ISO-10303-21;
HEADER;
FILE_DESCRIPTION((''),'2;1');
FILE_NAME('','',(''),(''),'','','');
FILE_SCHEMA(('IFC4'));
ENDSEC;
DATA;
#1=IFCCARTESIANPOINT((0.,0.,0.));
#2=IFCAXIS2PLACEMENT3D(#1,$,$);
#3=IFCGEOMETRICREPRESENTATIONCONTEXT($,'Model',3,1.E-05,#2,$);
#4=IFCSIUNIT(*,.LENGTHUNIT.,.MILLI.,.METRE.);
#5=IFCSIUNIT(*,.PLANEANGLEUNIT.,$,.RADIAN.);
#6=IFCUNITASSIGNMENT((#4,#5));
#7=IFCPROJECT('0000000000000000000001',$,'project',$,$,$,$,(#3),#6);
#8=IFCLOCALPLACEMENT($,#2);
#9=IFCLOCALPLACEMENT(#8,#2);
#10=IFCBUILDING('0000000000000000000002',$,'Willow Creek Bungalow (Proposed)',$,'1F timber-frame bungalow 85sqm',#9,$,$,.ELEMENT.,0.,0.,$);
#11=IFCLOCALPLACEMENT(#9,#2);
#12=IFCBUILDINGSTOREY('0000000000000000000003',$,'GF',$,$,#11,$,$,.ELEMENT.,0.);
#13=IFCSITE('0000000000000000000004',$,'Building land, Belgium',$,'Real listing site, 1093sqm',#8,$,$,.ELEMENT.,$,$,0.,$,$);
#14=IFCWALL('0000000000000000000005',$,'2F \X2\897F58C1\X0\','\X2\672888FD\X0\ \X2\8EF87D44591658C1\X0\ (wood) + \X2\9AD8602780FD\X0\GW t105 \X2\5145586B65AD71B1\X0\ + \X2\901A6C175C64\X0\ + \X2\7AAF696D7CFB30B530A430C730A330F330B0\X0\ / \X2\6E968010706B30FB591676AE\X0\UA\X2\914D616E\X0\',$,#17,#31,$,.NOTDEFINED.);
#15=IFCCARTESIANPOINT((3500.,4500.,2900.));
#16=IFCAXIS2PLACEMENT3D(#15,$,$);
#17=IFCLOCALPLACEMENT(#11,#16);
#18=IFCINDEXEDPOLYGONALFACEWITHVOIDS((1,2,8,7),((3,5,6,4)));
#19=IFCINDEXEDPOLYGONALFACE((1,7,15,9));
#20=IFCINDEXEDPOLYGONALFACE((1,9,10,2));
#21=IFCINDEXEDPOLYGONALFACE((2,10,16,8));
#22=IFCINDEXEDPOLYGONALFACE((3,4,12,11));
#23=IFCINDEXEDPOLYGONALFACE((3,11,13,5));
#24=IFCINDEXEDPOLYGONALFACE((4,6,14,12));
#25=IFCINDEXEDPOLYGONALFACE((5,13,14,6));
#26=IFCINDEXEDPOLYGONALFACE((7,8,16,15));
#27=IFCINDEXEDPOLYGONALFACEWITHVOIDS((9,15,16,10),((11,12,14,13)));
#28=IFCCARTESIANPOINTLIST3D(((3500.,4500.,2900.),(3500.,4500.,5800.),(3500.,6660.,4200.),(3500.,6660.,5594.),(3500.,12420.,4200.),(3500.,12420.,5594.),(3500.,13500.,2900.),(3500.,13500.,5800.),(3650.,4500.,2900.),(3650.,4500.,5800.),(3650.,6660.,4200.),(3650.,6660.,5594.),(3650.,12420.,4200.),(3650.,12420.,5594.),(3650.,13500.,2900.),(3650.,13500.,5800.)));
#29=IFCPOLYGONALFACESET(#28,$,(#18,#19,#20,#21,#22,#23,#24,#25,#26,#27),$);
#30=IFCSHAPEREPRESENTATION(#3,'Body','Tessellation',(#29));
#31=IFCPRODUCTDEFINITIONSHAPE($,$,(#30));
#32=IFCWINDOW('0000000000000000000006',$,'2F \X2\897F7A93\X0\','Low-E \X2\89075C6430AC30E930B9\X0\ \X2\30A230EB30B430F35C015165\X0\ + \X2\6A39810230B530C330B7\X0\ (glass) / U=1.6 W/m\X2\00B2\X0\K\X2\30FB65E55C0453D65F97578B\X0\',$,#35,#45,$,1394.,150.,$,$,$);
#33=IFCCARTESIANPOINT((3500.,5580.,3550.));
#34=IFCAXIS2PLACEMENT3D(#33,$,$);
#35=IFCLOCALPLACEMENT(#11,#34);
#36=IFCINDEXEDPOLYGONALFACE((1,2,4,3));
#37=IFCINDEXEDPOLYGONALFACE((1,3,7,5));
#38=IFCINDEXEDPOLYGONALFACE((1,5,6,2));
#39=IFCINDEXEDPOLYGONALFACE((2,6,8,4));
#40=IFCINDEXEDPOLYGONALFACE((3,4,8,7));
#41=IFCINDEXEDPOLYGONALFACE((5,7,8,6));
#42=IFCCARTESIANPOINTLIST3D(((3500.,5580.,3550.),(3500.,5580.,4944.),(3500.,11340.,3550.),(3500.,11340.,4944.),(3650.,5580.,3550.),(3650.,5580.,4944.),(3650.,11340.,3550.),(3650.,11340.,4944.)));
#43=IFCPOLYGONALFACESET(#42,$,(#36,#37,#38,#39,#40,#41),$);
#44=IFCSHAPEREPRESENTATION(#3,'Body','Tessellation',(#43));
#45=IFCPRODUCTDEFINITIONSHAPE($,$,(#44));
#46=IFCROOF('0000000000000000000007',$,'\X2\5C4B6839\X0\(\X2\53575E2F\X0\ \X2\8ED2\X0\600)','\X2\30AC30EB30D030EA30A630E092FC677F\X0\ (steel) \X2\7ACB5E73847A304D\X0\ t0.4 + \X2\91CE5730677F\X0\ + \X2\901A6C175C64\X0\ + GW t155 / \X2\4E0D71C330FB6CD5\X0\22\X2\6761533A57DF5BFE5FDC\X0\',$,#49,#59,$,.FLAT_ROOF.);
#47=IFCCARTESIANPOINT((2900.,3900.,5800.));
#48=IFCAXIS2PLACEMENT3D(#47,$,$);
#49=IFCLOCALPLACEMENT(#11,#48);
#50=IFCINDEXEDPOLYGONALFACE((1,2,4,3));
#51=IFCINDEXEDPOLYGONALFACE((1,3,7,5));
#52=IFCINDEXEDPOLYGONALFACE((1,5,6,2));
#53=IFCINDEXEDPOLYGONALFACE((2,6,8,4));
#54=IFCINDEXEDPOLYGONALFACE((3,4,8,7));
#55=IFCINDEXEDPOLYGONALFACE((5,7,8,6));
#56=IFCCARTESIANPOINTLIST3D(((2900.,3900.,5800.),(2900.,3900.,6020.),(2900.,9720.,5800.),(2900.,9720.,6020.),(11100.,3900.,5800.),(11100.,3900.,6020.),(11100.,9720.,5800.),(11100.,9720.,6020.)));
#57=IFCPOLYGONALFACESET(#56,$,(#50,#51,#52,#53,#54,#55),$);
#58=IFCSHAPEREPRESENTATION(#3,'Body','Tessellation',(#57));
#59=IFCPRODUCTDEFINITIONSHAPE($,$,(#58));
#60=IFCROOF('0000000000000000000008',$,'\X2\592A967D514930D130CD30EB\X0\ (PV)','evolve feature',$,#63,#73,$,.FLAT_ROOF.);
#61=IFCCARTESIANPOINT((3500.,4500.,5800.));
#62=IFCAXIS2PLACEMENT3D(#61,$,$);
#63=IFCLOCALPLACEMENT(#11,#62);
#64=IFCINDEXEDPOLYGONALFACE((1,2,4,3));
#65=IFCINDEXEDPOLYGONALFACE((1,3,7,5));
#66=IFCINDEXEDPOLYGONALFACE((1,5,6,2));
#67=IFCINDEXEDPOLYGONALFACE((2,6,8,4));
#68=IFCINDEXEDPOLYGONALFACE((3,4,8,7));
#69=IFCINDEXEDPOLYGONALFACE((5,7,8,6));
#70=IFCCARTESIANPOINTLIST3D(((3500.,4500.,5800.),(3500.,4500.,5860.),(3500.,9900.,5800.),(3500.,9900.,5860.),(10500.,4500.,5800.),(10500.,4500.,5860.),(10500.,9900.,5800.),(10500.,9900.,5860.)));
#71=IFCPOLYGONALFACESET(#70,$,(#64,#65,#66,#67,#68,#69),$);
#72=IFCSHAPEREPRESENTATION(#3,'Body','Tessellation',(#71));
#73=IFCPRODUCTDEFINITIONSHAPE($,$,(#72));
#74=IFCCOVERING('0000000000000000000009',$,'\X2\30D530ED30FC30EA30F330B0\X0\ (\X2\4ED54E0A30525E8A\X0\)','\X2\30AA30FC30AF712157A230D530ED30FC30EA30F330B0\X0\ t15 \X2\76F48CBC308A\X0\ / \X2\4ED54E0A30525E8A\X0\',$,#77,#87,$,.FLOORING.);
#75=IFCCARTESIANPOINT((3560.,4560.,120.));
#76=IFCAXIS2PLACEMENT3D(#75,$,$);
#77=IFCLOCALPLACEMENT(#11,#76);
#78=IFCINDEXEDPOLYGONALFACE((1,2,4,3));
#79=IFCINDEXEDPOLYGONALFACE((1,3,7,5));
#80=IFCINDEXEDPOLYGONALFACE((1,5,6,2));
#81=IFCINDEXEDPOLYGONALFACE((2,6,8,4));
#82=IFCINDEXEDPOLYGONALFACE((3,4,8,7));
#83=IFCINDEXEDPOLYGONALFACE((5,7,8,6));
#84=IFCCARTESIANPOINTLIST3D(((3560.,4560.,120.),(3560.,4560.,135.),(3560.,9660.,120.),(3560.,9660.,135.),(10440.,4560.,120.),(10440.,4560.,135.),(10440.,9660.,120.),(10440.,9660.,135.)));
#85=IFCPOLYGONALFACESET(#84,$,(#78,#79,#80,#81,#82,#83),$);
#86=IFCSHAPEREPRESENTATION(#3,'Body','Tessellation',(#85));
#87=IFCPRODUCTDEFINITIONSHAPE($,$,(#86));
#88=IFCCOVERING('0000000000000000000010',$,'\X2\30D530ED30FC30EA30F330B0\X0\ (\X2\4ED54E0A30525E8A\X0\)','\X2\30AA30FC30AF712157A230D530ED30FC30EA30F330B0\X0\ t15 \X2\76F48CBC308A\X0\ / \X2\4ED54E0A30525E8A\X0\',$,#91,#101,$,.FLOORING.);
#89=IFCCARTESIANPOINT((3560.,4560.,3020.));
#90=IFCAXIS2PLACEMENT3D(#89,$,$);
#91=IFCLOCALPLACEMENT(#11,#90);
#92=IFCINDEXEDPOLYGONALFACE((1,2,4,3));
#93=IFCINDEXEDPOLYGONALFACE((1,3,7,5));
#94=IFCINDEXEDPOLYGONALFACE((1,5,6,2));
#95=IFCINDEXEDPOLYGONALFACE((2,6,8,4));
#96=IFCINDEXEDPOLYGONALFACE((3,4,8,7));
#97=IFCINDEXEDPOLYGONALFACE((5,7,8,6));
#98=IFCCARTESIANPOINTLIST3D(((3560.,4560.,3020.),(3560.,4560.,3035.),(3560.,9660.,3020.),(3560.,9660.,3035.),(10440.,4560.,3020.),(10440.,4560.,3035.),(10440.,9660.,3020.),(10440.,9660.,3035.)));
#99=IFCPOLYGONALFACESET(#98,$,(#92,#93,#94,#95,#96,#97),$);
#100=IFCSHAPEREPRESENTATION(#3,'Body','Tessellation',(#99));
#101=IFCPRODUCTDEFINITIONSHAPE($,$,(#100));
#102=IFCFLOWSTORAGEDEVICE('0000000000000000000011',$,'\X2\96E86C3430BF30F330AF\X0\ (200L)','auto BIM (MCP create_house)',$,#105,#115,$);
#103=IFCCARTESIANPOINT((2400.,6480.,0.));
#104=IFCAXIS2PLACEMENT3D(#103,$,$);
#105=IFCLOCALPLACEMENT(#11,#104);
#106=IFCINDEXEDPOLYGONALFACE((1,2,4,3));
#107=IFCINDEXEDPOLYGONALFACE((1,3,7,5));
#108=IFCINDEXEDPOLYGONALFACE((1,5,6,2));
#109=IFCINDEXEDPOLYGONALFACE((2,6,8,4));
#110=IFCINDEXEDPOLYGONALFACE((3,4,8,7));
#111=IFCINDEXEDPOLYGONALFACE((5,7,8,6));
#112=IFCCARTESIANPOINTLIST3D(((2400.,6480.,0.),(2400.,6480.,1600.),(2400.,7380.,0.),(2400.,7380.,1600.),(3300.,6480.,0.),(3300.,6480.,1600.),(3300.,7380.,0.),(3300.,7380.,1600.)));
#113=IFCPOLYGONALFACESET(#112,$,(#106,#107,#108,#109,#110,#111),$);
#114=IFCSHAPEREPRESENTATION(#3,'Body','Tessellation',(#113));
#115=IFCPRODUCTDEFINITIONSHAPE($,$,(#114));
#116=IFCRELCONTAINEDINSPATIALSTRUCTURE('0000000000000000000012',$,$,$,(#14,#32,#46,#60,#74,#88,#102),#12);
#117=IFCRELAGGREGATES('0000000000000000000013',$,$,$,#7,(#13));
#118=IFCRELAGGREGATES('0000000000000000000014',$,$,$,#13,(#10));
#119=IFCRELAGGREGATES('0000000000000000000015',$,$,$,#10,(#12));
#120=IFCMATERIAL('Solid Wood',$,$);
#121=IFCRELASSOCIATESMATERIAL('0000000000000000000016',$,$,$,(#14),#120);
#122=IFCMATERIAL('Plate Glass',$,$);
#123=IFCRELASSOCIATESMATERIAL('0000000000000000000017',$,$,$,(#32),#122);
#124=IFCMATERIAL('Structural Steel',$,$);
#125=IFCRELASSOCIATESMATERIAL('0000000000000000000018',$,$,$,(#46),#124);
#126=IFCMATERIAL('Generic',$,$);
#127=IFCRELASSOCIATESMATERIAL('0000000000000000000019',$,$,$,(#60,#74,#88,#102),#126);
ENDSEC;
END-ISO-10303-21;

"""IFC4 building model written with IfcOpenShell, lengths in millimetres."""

from ifc_helpers import new_model, si_unit, frame, frame_2d, origin, place, context, project, spatial, rectangle, extrude, material, element, fill, save


model = new_model("IFC4")

# Units and contexts
model_context = context("Model", 3, precision=1e-05, world=origin())
ifc_project = project(units=[si_unit("LENGTHUNIT", "METRE", prefix="MILLI"), si_unit("PLANEANGLEUNIT", "RADIAN")], contexts=[model_context])

# Site, building, storey
site_placement = place(None, origin())
site = spatial("IfcSite", under=ifc_project, at=site_placement, Name="Building land, Belgium", ObjectType="Real listing site, 1093sqm", CompositionType="ELEMENT", RefElevation=0.0)
building_placement = place(site_placement, origin())
building = spatial("IfcBuilding", under=site, at=building_placement, Name="Willow Creek Bungalow (Proposed)", ObjectType="1F timber-frame bungalow 85sqm", CompositionType="ELEMENT", ElevationOfRefHeight=0.0, ElevationOfTerrain=0.0)
storey_placement = place(building_placement, origin())
storey = spatial("IfcBuildingStorey", under=building, at=storey_placement, Name="GF", CompositionType="ELEMENT", Elevation=0.0)

# Shared definitions
ifc_material_1 = material(Name="Solid Wood")
ifc_material_2 = material(Name="Generic")

# Shared definitions
ifc_material_3 = material(Name="Plate Glass")

# Wall, opening, window
wall_1_placement = place(storey_placement, frame((3500.0, 4500.0, 2900.0)))
wall_1 = element("IfcWall", 1, at=wall_1_placement, inside=storey, material=ifc_material_1, Name="2F 西壁", Description="木製 軸組外壁 (wood) + 高性能GW t105 充填断熱 + 通気層 + 窯業系サイディング / 準耐火・外皮UA配慮", PredefinedType="NOTDEFINED", context=model_context, shape_type="SweptSolid", body=[
    extrude(rectangle(XDim=150.0, YDim=9000.0, at=frame_2d((75.0, 4500.0))), frame((3500.0, 4500.0, 2900.0)), (0.0, 0.0, 1.0), 2900.0),
])
opening_1_placement = place(storey_placement, frame((3500.0, 5580.0, 3550.0)))
opening_1 = element("IfcOpeningElement", 2, at=opening_1_placement, cuts=wall_1, PredefinedType="NOTDEFINED", context=model_context, shape_type="SweptSolid", body=[
    extrude(rectangle(XDim=150.0, YDim=5760.0, at=frame_2d((75.0, 2880.0))), frame((3500.0, 5580.0, 3550.0)), (0.0, 0.0, 1.0), 1394.0),
])
window_1_placement = place(storey_placement, frame((3500.0, 5580.0, 3550.0)))
window_1 = element("IfcWindow", 3, at=window_1_placement, inside=storey, material=ifc_material_3, Name="2F 西窓", Description="Low-E 複層ガラス アルゴン封入 + 樹脂サッシ (glass) / U=1.6 W/m²K・日射取得型", OverallHeight=1394.0, OverallWidth=150.0, context=model_context, shape_type="SweptSolid", body=[
    extrude(rectangle(XDim=150.0, YDim=5760.0, at=frame_2d((75.0, 2880.0))), frame((3500.0, 5580.0, 3550.0)), (0.0, 0.0, 1.0), 1394.0),
])
fill(opening_1, window_1)

# Roofs
ifc_material_4 = material(Name="Structural Steel")
for number, where, name in (
    (4, (2900.0, 3900.0, 5800.0), "屋根(南帯 軒600)"),
):
    element("IfcRoof", number, at=place(storey_placement, frame(where)), inside=storey, material=ifc_material_4, Name=name, Description="ガルバリウム鋼板 (steel) 立平葺き t0.4 + 野地板 + 通気層 + GW t155 / 不燃・法22条区域対応", PredefinedType="FLAT_ROOF", context=model_context, shape_type="SweptSolid", body=[
        extrude(rectangle(XDim=8200.0, YDim=5820.0, at=frame_2d((4100.0, 2910.0))), frame((2900.0, 3900.0, 5800.0)), (0.0, 0.0, 1.0), 220.0),
    ])
roof_placement = place(storey_placement, frame((3500.0, 4500.0, 5800.0)))
element("IfcRoof", 5, at=roof_placement, inside=storey, material=ifc_material_2, Name="太陽光パネル (PV)", Description="evolve feature", PredefinedType="FLAT_ROOF", context=model_context, shape_type="SweptSolid", body=[
    extrude(rectangle(XDim=7000.0, YDim=5400.0, at=frame_2d((3500.0, 2700.0))), frame((3500.0, 4500.0, 5800.0)), (0.0, 0.0, 1.0), 60.0),
])

# Coverings
covering_1_placement = place(storey_placement, frame((3560.0, 4560.0, 120.0)))
element("IfcCovering", 6, at=covering_1_placement, inside=storey, material=ifc_material_2, Name="フローリング (仕上げ床)", Description="オーク無垢フローリング t15 直貼り / 仕上げ床", PredefinedType="FLOORING", context=model_context, shape_type="SweptSolid", body=[
    extrude(rectangle(XDim=6880.0, YDim=5100.0, at=frame_2d((3440.0, 2550.0))), frame((3560.0, 4560.0, 120.0)), (0.0, 0.0, 1.0), 15.0),
])
covering_2_placement = place(storey_placement, frame((3560.0, 4560.0, 3020.0)))
element("IfcCovering", 7, at=covering_2_placement, inside=storey, material=ifc_material_2, Name="フローリング (仕上げ床)", Description="オーク無垢フローリング t15 直貼り / 仕上げ床", PredefinedType="FLOORING", context=model_context, shape_type="SweptSolid", body=[
    extrude(rectangle(XDim=6880.0, YDim=5100.0, at=frame_2d((3440.0, 2550.0))), frame((3560.0, 4560.0, 3020.0)), (0.0, 0.0, 1.0), 15.0),
])

# Flow storage device
flow_storage_device_placement = place(storey_placement, frame((2400.0, 6480.0, 0.0)))
element("IfcFlowStorageDevice", 8, at=flow_storage_device_placement, inside=storey, material=ifc_material_2, Name="雨水タンク (200L)", Description="auto BIM (MCP create_house)", context=model_context, shape_type="SweptSolid", body=[
    extrude(rectangle(XDim=900.0, YDim=900.0, at=frame_2d((450.0, 450.0))), frame((2400.0, 6480.0, 0.0)), (0.0, 0.0, 1.0), 1600.0),
])

save(model, "model.ifc")
